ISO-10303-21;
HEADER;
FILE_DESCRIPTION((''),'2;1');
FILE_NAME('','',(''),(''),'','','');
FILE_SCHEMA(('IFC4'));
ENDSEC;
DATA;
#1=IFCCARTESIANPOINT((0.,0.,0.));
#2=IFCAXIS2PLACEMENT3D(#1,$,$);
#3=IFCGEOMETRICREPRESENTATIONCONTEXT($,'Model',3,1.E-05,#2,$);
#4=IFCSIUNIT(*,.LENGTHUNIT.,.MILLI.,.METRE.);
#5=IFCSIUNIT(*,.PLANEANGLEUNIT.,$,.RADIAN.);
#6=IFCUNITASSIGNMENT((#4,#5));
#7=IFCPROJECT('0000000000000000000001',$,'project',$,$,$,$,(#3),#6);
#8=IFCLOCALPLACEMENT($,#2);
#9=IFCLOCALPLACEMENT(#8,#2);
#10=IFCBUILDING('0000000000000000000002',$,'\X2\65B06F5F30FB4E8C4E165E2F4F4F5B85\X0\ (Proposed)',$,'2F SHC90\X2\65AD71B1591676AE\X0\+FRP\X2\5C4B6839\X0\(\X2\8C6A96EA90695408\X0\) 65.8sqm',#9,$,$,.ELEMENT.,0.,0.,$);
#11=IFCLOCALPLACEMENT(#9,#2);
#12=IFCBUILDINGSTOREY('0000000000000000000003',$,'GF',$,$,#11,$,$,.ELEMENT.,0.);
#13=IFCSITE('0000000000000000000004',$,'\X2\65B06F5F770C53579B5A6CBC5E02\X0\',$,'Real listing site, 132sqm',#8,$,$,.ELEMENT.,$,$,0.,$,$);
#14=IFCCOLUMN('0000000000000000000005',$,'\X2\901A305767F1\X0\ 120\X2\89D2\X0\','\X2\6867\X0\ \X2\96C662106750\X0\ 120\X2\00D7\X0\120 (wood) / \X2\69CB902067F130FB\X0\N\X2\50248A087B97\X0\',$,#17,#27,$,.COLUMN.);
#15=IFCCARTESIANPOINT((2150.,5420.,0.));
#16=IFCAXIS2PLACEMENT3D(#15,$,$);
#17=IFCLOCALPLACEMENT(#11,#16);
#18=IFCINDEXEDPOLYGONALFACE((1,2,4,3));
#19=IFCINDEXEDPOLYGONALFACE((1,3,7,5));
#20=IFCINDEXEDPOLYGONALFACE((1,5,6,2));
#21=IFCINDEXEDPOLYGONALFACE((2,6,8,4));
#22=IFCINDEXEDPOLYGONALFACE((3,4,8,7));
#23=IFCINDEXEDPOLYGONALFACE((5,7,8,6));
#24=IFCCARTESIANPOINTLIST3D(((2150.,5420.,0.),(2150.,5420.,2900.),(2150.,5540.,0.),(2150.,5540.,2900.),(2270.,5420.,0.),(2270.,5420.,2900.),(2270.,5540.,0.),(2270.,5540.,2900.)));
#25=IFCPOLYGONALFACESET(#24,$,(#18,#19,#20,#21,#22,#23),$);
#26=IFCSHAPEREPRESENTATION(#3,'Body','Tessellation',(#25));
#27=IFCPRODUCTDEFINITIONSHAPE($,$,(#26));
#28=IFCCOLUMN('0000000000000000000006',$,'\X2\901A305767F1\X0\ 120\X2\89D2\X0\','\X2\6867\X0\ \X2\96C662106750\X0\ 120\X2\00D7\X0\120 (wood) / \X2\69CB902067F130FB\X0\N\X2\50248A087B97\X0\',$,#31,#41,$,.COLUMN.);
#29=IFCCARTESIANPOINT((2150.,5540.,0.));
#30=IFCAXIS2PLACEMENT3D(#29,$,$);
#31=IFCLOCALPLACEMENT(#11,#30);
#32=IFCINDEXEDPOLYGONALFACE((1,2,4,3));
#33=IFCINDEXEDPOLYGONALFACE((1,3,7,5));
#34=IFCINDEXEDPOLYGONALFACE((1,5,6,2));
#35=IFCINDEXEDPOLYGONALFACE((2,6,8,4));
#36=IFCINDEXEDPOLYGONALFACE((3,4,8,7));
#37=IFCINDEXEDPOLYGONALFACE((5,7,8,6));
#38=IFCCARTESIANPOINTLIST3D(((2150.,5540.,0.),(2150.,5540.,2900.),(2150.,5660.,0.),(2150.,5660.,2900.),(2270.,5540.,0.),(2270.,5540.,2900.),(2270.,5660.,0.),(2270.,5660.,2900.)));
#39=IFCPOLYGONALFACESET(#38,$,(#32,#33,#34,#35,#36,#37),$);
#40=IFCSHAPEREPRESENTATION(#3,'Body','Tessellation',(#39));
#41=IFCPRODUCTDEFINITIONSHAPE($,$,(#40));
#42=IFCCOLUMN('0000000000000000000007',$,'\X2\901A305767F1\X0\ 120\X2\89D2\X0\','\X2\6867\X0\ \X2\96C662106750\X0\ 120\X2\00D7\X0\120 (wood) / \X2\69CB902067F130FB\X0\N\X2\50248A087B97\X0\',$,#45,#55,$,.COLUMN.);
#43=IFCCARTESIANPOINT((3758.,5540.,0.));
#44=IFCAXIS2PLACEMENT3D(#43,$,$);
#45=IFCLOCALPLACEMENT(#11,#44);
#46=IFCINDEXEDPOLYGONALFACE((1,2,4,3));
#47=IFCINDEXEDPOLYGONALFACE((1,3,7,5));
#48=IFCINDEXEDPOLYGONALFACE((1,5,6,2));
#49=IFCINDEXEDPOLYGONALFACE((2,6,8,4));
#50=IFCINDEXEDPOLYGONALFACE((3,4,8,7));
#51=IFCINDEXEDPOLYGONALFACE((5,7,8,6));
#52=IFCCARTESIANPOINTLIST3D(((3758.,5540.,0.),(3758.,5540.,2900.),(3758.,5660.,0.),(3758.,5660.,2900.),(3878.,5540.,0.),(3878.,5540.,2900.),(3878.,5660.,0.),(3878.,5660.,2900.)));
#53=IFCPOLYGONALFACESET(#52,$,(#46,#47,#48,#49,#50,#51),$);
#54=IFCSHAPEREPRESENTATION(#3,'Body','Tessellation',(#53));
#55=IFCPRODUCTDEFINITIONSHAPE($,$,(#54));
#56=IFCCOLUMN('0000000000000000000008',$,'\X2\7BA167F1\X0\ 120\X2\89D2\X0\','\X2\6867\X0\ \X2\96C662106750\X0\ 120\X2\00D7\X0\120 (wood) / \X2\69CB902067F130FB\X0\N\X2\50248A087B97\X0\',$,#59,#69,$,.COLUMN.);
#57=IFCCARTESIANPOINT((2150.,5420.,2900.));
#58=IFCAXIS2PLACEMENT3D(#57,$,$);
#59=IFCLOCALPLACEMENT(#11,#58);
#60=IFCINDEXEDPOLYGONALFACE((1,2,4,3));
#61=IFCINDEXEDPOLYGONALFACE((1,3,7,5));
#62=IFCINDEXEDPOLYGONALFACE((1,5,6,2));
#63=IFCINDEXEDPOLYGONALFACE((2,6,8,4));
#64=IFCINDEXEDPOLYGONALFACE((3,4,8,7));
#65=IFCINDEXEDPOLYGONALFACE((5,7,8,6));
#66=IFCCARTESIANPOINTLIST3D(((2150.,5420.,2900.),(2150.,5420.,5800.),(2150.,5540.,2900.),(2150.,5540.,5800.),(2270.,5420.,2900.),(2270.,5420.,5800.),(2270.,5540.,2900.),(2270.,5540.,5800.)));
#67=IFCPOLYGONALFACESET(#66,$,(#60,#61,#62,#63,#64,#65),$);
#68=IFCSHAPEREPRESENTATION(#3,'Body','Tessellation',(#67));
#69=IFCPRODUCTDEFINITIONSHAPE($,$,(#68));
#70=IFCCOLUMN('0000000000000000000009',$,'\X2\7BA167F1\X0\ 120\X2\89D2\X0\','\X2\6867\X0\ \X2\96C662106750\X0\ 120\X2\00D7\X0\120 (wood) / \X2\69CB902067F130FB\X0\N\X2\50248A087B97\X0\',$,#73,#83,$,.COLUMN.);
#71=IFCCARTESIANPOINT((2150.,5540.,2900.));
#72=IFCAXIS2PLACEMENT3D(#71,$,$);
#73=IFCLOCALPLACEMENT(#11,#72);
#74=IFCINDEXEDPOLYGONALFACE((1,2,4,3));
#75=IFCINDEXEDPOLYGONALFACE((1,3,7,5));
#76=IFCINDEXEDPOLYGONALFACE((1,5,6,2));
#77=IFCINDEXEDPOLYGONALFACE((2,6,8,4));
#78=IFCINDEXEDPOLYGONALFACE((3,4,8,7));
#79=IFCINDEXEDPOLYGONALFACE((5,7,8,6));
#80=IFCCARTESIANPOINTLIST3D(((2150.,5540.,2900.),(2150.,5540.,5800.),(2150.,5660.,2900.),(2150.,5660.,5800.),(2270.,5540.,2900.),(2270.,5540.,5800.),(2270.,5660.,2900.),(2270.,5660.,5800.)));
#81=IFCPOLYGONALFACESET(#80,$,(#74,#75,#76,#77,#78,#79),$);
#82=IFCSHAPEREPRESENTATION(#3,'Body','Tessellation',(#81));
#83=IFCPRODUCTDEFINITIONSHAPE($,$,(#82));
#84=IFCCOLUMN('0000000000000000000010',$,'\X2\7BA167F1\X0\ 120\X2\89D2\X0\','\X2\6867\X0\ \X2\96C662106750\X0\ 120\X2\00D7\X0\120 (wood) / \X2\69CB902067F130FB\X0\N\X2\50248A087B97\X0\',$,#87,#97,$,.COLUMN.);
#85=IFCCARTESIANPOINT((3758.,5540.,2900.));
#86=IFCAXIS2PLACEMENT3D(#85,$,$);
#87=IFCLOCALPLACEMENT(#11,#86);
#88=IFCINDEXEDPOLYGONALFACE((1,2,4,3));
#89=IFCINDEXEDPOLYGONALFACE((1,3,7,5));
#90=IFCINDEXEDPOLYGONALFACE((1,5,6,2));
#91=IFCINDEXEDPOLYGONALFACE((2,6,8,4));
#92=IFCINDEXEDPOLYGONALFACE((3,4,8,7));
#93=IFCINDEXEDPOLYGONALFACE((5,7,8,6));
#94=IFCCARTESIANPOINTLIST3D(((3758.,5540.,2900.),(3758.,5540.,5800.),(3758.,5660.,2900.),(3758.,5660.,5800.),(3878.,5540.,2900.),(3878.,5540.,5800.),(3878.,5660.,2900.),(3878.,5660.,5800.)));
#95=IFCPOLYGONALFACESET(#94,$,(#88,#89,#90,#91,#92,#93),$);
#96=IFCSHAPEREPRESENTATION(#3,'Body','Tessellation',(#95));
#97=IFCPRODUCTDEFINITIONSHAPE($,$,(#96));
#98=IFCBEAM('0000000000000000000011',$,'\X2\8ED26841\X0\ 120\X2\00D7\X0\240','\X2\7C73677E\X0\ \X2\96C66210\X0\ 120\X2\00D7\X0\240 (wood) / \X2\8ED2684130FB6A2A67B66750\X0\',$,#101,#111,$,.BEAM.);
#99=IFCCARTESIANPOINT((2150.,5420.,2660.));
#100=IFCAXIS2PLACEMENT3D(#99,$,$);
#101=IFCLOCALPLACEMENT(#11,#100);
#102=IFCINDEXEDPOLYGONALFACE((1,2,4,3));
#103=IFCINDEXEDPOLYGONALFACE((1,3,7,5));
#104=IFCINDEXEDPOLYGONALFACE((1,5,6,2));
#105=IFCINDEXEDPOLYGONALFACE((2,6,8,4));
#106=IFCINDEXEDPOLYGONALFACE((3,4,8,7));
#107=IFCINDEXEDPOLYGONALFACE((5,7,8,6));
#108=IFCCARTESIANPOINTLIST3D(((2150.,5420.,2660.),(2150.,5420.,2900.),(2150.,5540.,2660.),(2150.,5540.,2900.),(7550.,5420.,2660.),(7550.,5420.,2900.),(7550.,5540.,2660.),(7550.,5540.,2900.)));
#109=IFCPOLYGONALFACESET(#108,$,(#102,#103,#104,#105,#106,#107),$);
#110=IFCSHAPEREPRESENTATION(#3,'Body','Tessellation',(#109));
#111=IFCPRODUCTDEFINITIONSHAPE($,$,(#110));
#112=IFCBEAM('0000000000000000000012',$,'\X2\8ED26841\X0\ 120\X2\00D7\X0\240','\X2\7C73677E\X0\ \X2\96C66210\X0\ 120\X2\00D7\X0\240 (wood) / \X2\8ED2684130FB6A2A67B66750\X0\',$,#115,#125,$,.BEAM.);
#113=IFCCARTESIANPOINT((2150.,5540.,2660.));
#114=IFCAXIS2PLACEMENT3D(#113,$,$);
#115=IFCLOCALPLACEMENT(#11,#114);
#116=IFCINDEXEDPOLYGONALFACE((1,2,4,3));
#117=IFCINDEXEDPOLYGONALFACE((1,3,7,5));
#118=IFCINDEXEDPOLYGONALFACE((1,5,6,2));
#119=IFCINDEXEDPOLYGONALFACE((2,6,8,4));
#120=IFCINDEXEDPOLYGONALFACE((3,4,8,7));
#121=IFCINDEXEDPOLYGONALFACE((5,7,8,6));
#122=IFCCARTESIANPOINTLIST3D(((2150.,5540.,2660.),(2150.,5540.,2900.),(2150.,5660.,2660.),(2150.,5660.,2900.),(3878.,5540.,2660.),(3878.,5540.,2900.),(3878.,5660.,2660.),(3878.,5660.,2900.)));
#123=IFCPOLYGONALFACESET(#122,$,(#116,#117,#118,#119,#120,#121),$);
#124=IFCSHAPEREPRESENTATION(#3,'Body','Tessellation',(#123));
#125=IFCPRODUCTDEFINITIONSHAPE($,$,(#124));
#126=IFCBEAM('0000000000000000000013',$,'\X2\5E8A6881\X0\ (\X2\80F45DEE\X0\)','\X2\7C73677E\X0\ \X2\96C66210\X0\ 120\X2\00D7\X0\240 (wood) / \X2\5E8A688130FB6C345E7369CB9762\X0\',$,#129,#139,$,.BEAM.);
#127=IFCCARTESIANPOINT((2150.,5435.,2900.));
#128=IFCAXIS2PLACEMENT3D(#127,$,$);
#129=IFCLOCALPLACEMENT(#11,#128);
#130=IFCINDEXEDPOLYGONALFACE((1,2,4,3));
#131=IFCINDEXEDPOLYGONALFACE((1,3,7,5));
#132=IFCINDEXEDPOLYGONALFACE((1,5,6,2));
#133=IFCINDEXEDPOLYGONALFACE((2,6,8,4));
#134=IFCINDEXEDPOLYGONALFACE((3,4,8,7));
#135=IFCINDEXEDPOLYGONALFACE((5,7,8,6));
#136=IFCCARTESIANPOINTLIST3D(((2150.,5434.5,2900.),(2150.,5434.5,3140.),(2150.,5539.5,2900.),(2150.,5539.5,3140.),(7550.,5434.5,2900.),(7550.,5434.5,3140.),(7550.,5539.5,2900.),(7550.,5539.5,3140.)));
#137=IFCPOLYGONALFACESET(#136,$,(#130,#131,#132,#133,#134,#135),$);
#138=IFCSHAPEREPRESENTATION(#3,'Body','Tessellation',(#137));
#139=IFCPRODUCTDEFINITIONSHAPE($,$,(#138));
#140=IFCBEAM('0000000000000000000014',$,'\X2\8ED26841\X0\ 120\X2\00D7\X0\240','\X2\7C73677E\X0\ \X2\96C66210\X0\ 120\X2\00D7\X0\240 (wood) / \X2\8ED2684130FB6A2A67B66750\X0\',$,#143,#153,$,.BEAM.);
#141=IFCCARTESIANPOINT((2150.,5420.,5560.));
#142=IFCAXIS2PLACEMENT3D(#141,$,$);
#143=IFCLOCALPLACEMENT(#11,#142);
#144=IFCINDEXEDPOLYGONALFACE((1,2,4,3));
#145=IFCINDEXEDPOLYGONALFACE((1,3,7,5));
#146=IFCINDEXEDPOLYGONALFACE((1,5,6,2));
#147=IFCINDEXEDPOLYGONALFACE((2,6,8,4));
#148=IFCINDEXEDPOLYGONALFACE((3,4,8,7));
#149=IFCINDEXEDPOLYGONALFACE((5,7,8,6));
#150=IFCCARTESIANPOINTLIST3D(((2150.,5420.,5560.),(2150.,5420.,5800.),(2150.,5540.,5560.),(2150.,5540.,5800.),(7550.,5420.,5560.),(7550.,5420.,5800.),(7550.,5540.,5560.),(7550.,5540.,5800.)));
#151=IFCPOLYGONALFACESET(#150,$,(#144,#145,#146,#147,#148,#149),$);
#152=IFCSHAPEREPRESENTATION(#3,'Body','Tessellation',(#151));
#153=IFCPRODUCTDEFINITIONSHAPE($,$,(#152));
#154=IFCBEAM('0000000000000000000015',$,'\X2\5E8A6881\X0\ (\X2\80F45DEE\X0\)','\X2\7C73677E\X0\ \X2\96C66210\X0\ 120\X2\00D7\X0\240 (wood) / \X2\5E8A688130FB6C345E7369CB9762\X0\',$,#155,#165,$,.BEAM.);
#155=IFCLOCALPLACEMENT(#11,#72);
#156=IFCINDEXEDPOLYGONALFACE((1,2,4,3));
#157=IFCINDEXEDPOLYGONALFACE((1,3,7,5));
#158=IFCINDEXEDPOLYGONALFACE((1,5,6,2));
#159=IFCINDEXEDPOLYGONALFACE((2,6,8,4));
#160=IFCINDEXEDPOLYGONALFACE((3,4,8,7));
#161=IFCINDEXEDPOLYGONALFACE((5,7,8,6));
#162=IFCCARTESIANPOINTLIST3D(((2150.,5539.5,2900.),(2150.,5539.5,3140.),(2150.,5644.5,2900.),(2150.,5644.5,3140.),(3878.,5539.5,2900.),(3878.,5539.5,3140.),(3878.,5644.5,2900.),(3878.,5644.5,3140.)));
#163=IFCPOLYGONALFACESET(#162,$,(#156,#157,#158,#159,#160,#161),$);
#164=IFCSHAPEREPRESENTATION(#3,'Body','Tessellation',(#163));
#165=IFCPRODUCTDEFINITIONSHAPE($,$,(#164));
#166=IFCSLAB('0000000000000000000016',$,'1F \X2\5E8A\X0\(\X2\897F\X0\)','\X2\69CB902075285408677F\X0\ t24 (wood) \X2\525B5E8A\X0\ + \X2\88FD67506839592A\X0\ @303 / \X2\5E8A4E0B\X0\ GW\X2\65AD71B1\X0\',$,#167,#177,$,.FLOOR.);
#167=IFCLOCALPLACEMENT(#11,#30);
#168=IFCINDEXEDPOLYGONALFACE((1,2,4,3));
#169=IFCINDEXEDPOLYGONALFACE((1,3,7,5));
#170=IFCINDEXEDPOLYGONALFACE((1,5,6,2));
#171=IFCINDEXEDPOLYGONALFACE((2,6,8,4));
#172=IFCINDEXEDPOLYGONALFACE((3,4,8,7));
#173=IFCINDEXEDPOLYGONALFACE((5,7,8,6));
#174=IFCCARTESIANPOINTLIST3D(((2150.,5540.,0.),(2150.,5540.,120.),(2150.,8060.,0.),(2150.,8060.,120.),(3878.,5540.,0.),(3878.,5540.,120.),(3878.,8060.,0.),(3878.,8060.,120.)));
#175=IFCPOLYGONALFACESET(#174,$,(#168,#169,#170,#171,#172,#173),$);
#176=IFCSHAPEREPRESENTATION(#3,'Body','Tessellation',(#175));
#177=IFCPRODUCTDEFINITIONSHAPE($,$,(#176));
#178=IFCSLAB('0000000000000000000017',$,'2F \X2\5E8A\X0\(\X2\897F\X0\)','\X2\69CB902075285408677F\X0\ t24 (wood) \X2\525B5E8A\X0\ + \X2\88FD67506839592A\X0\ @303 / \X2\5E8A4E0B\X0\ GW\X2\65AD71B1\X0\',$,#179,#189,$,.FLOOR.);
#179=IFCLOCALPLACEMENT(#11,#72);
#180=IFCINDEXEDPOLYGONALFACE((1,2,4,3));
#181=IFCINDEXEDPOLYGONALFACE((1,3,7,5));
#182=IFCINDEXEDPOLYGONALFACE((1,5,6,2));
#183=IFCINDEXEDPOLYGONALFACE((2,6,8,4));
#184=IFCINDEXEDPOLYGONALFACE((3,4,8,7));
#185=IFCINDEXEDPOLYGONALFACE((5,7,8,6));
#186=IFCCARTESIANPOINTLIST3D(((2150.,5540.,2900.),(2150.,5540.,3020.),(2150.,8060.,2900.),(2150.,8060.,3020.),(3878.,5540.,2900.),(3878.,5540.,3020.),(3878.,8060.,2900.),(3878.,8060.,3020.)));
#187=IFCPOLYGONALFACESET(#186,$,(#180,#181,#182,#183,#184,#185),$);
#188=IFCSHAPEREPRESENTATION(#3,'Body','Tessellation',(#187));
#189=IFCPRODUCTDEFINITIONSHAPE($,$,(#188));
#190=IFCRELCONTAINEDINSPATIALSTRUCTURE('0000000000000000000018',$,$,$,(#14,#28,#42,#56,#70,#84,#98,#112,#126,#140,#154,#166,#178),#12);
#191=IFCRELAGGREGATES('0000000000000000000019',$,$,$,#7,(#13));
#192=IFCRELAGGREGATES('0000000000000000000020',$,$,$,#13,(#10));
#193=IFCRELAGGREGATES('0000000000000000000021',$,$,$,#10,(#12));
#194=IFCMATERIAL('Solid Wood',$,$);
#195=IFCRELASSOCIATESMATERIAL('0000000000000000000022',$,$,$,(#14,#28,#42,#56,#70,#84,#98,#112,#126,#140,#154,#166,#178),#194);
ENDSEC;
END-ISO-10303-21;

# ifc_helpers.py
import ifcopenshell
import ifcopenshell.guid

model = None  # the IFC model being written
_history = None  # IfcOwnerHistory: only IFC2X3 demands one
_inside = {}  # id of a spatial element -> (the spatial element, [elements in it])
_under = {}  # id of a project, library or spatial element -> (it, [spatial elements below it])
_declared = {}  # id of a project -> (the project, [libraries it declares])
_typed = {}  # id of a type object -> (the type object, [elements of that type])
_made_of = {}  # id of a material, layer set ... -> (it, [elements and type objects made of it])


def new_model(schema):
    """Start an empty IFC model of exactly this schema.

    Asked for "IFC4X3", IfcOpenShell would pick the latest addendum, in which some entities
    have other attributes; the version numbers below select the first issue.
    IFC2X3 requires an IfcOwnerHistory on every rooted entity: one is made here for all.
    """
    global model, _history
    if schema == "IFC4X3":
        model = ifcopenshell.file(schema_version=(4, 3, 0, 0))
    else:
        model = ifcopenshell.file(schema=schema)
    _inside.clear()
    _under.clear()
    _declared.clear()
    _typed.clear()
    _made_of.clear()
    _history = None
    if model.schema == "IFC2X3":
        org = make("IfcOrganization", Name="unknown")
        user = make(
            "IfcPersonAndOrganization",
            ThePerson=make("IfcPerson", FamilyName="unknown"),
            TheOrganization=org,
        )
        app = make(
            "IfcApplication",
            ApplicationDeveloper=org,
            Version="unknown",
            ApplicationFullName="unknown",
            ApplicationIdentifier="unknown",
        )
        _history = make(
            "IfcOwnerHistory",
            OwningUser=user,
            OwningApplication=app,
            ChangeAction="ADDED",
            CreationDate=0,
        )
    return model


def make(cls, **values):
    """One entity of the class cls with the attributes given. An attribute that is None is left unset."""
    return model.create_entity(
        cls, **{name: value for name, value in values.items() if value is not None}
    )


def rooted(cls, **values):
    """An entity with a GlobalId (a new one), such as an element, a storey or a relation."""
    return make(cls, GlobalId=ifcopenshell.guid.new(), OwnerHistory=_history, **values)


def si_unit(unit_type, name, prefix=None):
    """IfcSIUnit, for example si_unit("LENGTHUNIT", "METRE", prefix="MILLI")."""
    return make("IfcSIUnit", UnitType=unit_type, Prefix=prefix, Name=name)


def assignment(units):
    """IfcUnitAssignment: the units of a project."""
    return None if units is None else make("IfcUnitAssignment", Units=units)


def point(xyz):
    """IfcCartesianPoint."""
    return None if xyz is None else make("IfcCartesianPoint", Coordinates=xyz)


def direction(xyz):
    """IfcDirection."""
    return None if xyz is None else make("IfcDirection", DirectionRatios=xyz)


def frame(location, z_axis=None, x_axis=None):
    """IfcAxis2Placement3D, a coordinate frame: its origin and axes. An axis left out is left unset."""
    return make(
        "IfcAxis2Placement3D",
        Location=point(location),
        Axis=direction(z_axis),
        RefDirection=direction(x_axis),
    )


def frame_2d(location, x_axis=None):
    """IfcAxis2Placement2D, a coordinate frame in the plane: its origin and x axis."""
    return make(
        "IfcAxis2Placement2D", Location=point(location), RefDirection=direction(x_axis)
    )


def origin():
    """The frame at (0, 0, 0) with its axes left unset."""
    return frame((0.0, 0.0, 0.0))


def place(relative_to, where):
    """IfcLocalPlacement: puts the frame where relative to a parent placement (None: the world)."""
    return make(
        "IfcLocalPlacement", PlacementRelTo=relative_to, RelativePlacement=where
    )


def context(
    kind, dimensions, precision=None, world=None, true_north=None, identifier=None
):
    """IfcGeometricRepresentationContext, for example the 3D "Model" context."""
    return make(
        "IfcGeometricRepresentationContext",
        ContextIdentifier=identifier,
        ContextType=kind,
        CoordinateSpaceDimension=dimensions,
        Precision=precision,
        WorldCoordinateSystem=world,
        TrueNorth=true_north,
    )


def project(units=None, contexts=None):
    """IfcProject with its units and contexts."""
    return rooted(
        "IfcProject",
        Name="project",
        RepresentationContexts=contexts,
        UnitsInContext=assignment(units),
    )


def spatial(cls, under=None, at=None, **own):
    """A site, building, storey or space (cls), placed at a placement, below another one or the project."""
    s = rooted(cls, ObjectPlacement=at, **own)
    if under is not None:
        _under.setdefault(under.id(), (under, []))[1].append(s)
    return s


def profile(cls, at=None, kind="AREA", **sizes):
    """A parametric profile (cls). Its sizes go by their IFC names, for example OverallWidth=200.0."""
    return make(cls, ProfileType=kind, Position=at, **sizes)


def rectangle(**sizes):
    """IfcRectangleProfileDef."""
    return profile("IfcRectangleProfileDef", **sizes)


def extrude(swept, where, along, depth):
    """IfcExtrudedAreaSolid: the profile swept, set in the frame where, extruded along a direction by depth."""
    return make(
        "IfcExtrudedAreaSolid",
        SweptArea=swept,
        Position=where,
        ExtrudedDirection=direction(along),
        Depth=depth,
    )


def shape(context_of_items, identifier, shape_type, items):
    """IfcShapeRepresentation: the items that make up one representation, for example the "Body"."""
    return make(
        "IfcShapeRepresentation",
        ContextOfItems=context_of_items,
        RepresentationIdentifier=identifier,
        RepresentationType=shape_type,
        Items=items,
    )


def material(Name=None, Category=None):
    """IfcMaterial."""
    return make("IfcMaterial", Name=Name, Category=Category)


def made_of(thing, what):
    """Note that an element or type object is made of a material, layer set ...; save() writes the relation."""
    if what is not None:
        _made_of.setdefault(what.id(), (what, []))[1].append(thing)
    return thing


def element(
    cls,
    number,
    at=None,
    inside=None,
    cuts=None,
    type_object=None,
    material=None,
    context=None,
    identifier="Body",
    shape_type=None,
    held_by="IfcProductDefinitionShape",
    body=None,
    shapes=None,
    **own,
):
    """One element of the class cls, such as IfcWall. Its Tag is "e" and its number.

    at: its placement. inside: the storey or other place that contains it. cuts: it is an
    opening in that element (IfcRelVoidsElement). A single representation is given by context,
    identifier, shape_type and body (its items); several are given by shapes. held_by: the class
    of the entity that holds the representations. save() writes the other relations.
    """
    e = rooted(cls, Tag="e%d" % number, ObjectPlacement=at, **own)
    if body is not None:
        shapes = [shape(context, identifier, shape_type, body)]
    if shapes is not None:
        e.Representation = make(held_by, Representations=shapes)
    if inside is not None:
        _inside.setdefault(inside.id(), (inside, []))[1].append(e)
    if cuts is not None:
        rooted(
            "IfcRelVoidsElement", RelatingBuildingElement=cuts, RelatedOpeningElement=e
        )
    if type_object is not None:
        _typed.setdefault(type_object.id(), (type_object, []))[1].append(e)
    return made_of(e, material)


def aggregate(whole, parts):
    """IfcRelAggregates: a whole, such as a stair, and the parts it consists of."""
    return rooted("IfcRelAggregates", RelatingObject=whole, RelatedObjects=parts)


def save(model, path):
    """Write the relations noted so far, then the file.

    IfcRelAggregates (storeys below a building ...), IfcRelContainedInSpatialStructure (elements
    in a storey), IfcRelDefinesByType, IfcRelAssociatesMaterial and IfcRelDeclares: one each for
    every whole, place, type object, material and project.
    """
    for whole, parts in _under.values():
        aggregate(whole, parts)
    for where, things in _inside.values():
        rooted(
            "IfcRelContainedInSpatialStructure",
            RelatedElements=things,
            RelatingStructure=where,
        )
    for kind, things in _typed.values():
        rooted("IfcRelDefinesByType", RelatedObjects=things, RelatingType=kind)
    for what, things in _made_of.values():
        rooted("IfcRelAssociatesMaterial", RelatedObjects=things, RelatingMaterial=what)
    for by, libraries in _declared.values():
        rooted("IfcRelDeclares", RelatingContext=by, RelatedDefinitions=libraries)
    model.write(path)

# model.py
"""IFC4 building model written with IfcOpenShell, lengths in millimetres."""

from ifc_helpers import new_model, si_unit, frame, frame_2d, origin, place, context, project, spatial, rectangle, extrude, material, element, save


model = new_model("IFC4")

# Units and contexts
model_context = context("Model", 3, precision=1e-05, world=origin())
ifc_project = project(units=[si_unit("LENGTHUNIT", "METRE", prefix="MILLI"), si_unit("PLANEANGLEUNIT", "RADIAN")], contexts=[model_context])

# Site, building, storey
site_placement = place(None, origin())
site = spatial("IfcSite", under=ifc_project, at=site_placement, Name="新潟県南魚沼市", ObjectType="Real listing site, 132sqm", CompositionType="ELEMENT", RefElevation=0.0)
building_placement = place(site_placement, origin())
building = spatial("IfcBuilding", under=site, at=building_placement, Name="新潟・二世帯住宅 (Proposed)", ObjectType="2F SHC90断熱外皮+FRP屋根(豪雪適合) 65.8sqm", CompositionType="ELEMENT", ElevationOfRefHeight=0.0, ElevationOfTerrain=0.0)
storey_placement = place(building_placement, origin())
storey = spatial("IfcBuildingStorey", under=building, at=storey_placement, Name="GF", CompositionType="ELEMENT", Elevation=0.0)

# Columns
ifc_material_1 = material(Name="Solid Wood")
column_1_placement = place(storey_placement, frame((2150.0, 5420.0, 0.0)))
element("IfcColumn", 1, at=column_1_placement, inside=storey, material=ifc_material_1, Name="通し柱 120角", Description="桧 集成材 120×120 (wood) / 構造柱・N値計算", PredefinedType="COLUMN", context=model_context, shape_type="SweptSolid", body=[
    extrude(rectangle(XDim=120.0, YDim=120.0, at=frame_2d((60.0, 60.0))), frame((2150.0, 5420.0, 0.0)), (0.0, 0.0, 1.0), 2900.0),
])
column_2_placement = place(storey_placement, frame((2150.0, 5540.0, 0.0)))
element("IfcColumn", 2, at=column_2_placement, inside=storey, material=ifc_material_1, Name="通し柱 120角", Description="桧 集成材 120×120 (wood) / 構造柱・N値計算", PredefinedType="COLUMN", context=model_context, shape_type="SweptSolid", body=[
    extrude(rectangle(XDim=120.0, YDim=120.0, at=frame_2d((60.0, 60.0))), frame((2150.0, 5540.0, 0.0)), (0.0, 0.0, 1.0), 2900.0),
])
column_3_placement = place(storey_placement, frame((3758.0, 5540.0, 0.0)))
element("IfcColumn", 3, at=column_3_placement, inside=storey, material=ifc_material_1, Name="通し柱 120角", Description="桧 集成材 120×120 (wood) / 構造柱・N値計算", PredefinedType="COLUMN", context=model_context, shape_type="SweptSolid", body=[
    extrude(rectangle(XDim=120.0, YDim=120.0, at=frame_2d((60.0, 60.0))), frame((3758.0, 5540.0, 0.0)), (0.0, 0.0, 1.0), 2900.0),
])
column_4_placement = place(storey_placement, frame((2150.0, 5420.0, 2900.0)))
element("IfcColumn", 4, at=column_4_placement, inside=storey, material=ifc_material_1, Name="管柱 120角", Description="桧 集成材 120×120 (wood) / 構造柱・N値計算", PredefinedType="COLUMN", context=model_context, shape_type="SweptSolid", body=[
    extrude(rectangle(XDim=120.0, YDim=120.0, at=frame_2d((60.0, 60.0))), frame((2150.0, 5420.0, 2900.0)), (0.0, 0.0, 1.0), 2900.0),
])
column_5_placement = place(storey_placement, frame((2150.0, 5540.0, 2900.0)))
element("IfcColumn", 5, at=column_5_placement, inside=storey, material=ifc_material_1, Name="管柱 120角", Description="桧 集成材 120×120 (wood) / 構造柱・N値計算", PredefinedType="COLUMN", context=model_context, shape_type="SweptSolid", body=[
    extrude(rectangle(XDim=120.0, YDim=120.0, at=frame_2d((60.0, 60.0))), frame((2150.0, 5540.0, 2900.0)), (0.0, 0.0, 1.0), 2900.0),
])
column_6_placement = place(storey_placement, frame((3758.0, 5540.0, 2900.0)))
element("IfcColumn", 6, at=column_6_placement, inside=storey, material=ifc_material_1, Name="管柱 120角", Description="桧 集成材 120×120 (wood) / 構造柱・N値計算", PredefinedType="COLUMN", context=model_context, shape_type="SweptSolid", body=[
    extrude(rectangle(XDim=120.0, YDim=120.0, at=frame_2d((60.0, 60.0))), frame((3758.0, 5540.0, 2900.0)), (0.0, 0.0, 1.0), 2900.0),
])

# Beams
beam_1_placement = place(storey_placement, frame((2150.0, 5420.0, 2660.0)))
element("IfcBeam", 7, at=beam_1_placement, inside=storey, material=ifc_material_1, Name="軒桁 120×240", Description="米松 集成 120×240 (wood) / 軒桁・横架材", PredefinedType="BEAM", context=model_context, shape_type="SweptSolid", body=[
    extrude(rectangle(XDim=5400.0, YDim=120.0, at=frame_2d((2700.0, 60.0))), frame((2150.0, 5420.0, 2660.0)), (0.0, 0.0, 1.0), 240.0),
])
beam_2_placement = place(storey_placement, frame((2150.0, 5540.0, 2660.0)))
element("IfcBeam", 8, at=beam_2_placement, inside=storey, material=ifc_material_1, Name="軒桁 120×240", Description="米松 集成 120×240 (wood) / 軒桁・横架材", PredefinedType="BEAM", context=model_context, shape_type="SweptSolid", body=[
    extrude(rectangle(XDim=1728.0, YDim=120.0, at=frame_2d((864.0, 60.0))), frame((2150.0, 5540.0, 2660.0)), (0.0, 0.0, 1.0), 240.0),
])
beam_3_placement = place(storey_placement, frame((2150.0, 5435.0, 2900.0)))
element("IfcBeam", 9, at=beam_3_placement, inside=storey, material=ifc_material_1, Name="床梁 (胴差)", Description="米松 集成 120×240 (wood) / 床梁・水平構面", PredefinedType="BEAM", context=model_context, shape_type="SweptSolid", body=[
    extrude(rectangle(XDim=5400.0, YDim=105.0, at=frame_2d((2700.0, 52.0))), frame((2150.0, 5435.0, 2900.0)), (0.0, 0.0, 1.0), 240.0),
])
beam_4_placement = place(storey_placement, frame((2150.0, 5420.0, 5560.0)))
element("IfcBeam", 10, at=beam_4_placement, inside=storey, material=ifc_material_1, Name="軒桁 120×240", Description="米松 集成 120×240 (wood) / 軒桁・横架材", PredefinedType="BEAM", context=model_context, shape_type="SweptSolid", body=[
    extrude(rectangle(XDim=5400.0, YDim=120.0, at=frame_2d((2700.0, 60.0))), frame((2150.0, 5420.0, 5560.0)), (0.0, 0.0, 1.0), 240.0),
])
beam_5_placement = place(storey_placement, frame((2150.0, 5540.0, 2900.0)))
element("IfcBeam", 11, at=beam_5_placement, inside=storey, material=ifc_material_1, Name="床梁 (胴差)", Description="米松 集成 120×240 (wood) / 床梁・水平構面", PredefinedType="BEAM", context=model_context, shape_type="SweptSolid", body=[
    extrude(rectangle(XDim=1728.0, YDim=105.0, at=frame_2d((864.0, 52.0))), frame((2150.0, 5540.0, 2900.0)), (0.0, 0.0, 1.0), 240.0),
])

# Slabs
slab_1_placement = place(storey_placement, frame((2150.0, 5540.0, 0.0)))
element("IfcSlab", 12, at=slab_1_placement, inside=storey, material=ifc_material_1, Name="1F 床(西)", Description="構造用合板 t24 (wood) 剛床 + 製材根太 @303 / 床下 GW断熱", PredefinedType="FLOOR", context=model_context, shape_type="SweptSolid", body=[
    extrude(rectangle(XDim=1728.0, YDim=2520.0, at=frame_2d((864.0, 1260.0))), frame((2150.0, 5540.0, 0.0)), (0.0, 0.0, 1.0), 120.0),
])
slab_2_placement = place(storey_placement, frame((2150.0, 5540.0, 2900.0)))
element("IfcSlab", 13, at=slab_2_placement, inside=storey, material=ifc_material_1, Name="2F 床(西)", Description="構造用合板 t24 (wood) 剛床 + 製材根太 @303 / 床下 GW断熱", PredefinedType="FLOOR", context=model_context, shape_type="SweptSolid", body=[
    extrude(rectangle(XDim=1728.0, YDim=2520.0, at=frame_2d((864.0, 1260.0))), frame((2150.0, 5540.0, 2900.0)), (0.0, 0.0, 1.0), 120.0),
])

save(model, "model.ifc")
